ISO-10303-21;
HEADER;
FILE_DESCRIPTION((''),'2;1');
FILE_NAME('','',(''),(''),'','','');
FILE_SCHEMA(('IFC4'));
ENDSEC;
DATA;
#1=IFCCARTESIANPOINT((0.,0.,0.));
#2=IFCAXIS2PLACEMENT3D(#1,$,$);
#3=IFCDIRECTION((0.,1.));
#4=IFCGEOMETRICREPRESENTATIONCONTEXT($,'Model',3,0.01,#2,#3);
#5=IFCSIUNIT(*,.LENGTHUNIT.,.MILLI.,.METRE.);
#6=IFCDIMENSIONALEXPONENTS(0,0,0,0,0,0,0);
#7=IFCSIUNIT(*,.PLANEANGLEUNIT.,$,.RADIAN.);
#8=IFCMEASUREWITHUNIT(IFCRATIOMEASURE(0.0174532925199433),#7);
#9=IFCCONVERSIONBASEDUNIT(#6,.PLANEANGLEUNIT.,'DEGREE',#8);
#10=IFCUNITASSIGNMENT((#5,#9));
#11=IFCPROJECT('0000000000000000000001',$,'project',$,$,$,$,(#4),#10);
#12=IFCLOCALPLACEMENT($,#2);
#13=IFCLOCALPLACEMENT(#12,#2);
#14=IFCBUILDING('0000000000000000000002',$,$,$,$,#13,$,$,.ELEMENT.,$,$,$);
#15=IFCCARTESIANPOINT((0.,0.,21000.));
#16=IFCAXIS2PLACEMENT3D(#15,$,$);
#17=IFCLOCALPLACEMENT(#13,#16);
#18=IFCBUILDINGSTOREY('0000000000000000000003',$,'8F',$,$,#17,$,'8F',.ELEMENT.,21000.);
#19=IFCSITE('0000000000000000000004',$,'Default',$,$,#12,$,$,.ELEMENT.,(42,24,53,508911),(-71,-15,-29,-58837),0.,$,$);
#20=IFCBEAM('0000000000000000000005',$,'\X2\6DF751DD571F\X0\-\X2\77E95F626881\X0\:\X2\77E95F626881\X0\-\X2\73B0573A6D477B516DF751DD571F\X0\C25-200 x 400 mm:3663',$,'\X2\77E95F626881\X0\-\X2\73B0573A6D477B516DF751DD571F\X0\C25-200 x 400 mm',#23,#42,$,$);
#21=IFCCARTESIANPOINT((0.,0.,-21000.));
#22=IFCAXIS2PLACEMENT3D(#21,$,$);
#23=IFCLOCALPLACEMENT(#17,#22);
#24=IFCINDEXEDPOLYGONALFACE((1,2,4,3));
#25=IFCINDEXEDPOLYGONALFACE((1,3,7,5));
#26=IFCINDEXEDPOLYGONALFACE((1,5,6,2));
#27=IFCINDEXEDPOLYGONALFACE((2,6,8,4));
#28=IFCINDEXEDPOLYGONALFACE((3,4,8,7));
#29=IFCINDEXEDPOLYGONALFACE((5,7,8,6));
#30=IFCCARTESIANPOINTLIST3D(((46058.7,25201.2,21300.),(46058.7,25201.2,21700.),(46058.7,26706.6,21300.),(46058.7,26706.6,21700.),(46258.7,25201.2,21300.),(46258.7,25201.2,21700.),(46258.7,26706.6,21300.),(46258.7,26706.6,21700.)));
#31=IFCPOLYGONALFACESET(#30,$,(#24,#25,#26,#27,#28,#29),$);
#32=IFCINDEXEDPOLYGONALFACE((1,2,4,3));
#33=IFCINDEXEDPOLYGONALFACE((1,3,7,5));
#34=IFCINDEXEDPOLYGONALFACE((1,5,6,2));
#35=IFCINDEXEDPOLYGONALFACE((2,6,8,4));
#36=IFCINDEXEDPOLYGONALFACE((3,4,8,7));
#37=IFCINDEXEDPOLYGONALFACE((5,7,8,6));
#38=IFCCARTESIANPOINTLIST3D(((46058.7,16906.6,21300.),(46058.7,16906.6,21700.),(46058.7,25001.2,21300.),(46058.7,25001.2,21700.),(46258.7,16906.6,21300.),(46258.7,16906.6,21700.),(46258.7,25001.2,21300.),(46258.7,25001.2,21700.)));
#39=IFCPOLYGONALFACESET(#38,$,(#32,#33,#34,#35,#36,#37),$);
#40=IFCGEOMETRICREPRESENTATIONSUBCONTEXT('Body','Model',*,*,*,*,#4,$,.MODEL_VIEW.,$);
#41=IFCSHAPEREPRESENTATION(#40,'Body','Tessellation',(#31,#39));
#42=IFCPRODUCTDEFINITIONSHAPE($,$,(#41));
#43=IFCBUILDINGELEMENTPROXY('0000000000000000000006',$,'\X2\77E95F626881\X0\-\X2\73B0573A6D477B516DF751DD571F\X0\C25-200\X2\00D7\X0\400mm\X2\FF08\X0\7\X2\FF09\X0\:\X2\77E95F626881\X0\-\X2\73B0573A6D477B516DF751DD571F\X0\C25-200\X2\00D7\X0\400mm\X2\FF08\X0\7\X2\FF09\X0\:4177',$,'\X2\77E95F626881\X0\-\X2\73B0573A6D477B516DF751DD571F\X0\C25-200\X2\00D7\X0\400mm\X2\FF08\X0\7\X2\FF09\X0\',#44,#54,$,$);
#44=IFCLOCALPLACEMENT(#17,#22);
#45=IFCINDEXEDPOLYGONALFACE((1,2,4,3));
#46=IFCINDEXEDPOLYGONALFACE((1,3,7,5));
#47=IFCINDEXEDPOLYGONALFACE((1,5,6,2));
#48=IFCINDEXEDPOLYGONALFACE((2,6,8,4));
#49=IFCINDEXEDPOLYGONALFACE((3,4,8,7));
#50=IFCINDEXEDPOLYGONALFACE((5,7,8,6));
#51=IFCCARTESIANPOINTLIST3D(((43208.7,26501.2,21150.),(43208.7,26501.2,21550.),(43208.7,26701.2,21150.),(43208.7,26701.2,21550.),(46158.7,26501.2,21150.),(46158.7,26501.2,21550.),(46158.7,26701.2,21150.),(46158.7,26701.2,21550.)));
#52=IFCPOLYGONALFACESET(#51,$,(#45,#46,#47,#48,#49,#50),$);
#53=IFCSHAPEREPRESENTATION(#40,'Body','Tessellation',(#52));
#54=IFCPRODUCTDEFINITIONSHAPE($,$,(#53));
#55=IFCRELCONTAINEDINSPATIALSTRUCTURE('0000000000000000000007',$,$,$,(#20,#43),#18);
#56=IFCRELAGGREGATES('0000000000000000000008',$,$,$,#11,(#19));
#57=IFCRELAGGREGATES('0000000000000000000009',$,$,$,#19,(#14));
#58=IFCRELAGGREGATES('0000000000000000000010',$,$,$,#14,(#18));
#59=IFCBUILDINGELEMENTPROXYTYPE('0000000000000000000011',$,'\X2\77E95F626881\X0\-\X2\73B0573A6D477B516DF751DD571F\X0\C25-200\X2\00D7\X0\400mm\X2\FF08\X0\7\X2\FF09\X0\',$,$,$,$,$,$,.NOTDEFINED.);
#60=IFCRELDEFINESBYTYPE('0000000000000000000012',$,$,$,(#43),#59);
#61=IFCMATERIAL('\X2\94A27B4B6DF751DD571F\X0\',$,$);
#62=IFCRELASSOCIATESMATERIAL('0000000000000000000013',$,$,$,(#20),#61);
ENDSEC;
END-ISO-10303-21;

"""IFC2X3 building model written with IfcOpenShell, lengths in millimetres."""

from ifc_helpers import new_model, entity, si_unit, converted_unit, direction, frame, frame_2d, origin, origin_2d_with_axis, place, context, subcontext, project, spatial, rectangle, extrude, source, transform, mapped, material, type_object, type_shapes, element, save


model = new_model("IFC2X3")

# Units and contexts
model_context = context("Model", 3, precision=0.01, world=origin(), true_north=direction((0.0, 1.0)))
body_context = subcontext(model_context, "Body", "Model", "MODEL_VIEW")
ifc_project = project(units=[si_unit("LENGTHUNIT", "METRE", prefix="MILLI"), converted_unit("PLANEANGLEUNIT", "DEGREE", entity("IfcRatioMeasure", 0.0174532925199433), si_unit("PLANEANGLEUNIT", "RADIAN"), dimensions=[0, 0, 0, 0, 0, 0, 0])], contexts=[model_context])

# Site, building, storey
site_placement = place(None, origin())
site = spatial("IfcSite", under=ifc_project, at=site_placement, Name="Default", CompositionType="ELEMENT", RefLatitude=(42, 24, 53, 508911), RefLongitude=(-71, -15, -29, -58837), RefElevation=0.0)
building_placement = place(site_placement, origin())
building = spatial("IfcBuilding", under=site, at=building_placement, CompositionType="ELEMENT")
storey_placement = place(building_placement, frame((0.0, 0.0, 21000.0)))
storey = spatial("IfcBuildingStorey", under=building, at=storey_placement, Name="8F", LongName="8F", CompositionType="ELEMENT", Elevation=21000.0)

# Beam
ifc_material = material(Name="钢筋混凝土")
shared_shape_1 = source(origin(), body_context, "Body", "SweptSolid", [
    extrude(rectangle(XDim=1505.4, YDim=200.0, at=origin_2d_with_axis()), frame((46158.7, 25953.9, 21300.0), z_axis=(0.0, 0.0, 1.0), x_axis=(0.0, -1.0, 0.0)), (0.0, 0.0, 1.0), 400.0),
    extrude(rectangle(XDim=8094.6, YDim=200.0, at=frame_2d((-115.0, 0.0), x_axis=(1.0, 0.0))), frame((46158.7, 21068.9, 21300.0), z_axis=(0.0, 0.0, 1.0), x_axis=(0.0, 1.0, 0.0)), (0.0, 0.0, 1.0), 400.0),
])
beam_1_placement = place(storey_placement, frame((0.0, 0.0, -21000.0)))
element("IfcBeam", 1, at=beam_1_placement, inside=storey, material=ifc_material, Name="混凝土-矩形梁:矩形梁-现场浇筑混凝土C25-200 x 400 mm:3663", ObjectType="矩形梁-现场浇筑混凝土C25-200 x 400 mm", context=body_context, shape_type="MappedRepresentation", body=[
    mapped(shared_shape_1, transform((0.0, 0.0, 0.0), scale=1.0)),
])

# Building element proxy
building_element_proxy_type_1 = type_object("IfcBuildingElementProxyType", Name="矩形梁-现场浇筑混凝土C25-200×400mm（7）", PredefinedType="NOTDEFINED")
shared_shape_2 = source(origin(), body_context, "Body", "SweptSolid", [
    extrude(rectangle(XDim=200.0, YDim=2950.0, at=origin_2d_with_axis()), frame((44683.7, 26601.2, 21150.0), z_axis=(0.0, 0.0, 1.0), x_axis=(0.0, 1.0, 0.0)), (0.0, 0.0, 1.0), 400.0),
])
type_shapes(building_element_proxy_type_1, [shared_shape_2])
proxy_1_placement = place(storey_placement, frame((0.0, 0.0, -21000.0)))
element("IfcBuildingElementProxy", 2, at=proxy_1_placement, inside=storey, type_object=building_element_proxy_type_1, Name="矩形梁-现场浇筑混凝土C25-200×400mm（7）:矩形梁-现场浇筑混凝土C25-200×400mm（7）:4177", ObjectType="矩形梁-现场浇筑混凝土C25-200×400mm（7）", context=body_context, shape_type="MappedRepresentation", body=[
    mapped(shared_shape_2, transform((0.0, 0.0, 0.0), scale=1.0)),
])

save(model, "model.ifc")
